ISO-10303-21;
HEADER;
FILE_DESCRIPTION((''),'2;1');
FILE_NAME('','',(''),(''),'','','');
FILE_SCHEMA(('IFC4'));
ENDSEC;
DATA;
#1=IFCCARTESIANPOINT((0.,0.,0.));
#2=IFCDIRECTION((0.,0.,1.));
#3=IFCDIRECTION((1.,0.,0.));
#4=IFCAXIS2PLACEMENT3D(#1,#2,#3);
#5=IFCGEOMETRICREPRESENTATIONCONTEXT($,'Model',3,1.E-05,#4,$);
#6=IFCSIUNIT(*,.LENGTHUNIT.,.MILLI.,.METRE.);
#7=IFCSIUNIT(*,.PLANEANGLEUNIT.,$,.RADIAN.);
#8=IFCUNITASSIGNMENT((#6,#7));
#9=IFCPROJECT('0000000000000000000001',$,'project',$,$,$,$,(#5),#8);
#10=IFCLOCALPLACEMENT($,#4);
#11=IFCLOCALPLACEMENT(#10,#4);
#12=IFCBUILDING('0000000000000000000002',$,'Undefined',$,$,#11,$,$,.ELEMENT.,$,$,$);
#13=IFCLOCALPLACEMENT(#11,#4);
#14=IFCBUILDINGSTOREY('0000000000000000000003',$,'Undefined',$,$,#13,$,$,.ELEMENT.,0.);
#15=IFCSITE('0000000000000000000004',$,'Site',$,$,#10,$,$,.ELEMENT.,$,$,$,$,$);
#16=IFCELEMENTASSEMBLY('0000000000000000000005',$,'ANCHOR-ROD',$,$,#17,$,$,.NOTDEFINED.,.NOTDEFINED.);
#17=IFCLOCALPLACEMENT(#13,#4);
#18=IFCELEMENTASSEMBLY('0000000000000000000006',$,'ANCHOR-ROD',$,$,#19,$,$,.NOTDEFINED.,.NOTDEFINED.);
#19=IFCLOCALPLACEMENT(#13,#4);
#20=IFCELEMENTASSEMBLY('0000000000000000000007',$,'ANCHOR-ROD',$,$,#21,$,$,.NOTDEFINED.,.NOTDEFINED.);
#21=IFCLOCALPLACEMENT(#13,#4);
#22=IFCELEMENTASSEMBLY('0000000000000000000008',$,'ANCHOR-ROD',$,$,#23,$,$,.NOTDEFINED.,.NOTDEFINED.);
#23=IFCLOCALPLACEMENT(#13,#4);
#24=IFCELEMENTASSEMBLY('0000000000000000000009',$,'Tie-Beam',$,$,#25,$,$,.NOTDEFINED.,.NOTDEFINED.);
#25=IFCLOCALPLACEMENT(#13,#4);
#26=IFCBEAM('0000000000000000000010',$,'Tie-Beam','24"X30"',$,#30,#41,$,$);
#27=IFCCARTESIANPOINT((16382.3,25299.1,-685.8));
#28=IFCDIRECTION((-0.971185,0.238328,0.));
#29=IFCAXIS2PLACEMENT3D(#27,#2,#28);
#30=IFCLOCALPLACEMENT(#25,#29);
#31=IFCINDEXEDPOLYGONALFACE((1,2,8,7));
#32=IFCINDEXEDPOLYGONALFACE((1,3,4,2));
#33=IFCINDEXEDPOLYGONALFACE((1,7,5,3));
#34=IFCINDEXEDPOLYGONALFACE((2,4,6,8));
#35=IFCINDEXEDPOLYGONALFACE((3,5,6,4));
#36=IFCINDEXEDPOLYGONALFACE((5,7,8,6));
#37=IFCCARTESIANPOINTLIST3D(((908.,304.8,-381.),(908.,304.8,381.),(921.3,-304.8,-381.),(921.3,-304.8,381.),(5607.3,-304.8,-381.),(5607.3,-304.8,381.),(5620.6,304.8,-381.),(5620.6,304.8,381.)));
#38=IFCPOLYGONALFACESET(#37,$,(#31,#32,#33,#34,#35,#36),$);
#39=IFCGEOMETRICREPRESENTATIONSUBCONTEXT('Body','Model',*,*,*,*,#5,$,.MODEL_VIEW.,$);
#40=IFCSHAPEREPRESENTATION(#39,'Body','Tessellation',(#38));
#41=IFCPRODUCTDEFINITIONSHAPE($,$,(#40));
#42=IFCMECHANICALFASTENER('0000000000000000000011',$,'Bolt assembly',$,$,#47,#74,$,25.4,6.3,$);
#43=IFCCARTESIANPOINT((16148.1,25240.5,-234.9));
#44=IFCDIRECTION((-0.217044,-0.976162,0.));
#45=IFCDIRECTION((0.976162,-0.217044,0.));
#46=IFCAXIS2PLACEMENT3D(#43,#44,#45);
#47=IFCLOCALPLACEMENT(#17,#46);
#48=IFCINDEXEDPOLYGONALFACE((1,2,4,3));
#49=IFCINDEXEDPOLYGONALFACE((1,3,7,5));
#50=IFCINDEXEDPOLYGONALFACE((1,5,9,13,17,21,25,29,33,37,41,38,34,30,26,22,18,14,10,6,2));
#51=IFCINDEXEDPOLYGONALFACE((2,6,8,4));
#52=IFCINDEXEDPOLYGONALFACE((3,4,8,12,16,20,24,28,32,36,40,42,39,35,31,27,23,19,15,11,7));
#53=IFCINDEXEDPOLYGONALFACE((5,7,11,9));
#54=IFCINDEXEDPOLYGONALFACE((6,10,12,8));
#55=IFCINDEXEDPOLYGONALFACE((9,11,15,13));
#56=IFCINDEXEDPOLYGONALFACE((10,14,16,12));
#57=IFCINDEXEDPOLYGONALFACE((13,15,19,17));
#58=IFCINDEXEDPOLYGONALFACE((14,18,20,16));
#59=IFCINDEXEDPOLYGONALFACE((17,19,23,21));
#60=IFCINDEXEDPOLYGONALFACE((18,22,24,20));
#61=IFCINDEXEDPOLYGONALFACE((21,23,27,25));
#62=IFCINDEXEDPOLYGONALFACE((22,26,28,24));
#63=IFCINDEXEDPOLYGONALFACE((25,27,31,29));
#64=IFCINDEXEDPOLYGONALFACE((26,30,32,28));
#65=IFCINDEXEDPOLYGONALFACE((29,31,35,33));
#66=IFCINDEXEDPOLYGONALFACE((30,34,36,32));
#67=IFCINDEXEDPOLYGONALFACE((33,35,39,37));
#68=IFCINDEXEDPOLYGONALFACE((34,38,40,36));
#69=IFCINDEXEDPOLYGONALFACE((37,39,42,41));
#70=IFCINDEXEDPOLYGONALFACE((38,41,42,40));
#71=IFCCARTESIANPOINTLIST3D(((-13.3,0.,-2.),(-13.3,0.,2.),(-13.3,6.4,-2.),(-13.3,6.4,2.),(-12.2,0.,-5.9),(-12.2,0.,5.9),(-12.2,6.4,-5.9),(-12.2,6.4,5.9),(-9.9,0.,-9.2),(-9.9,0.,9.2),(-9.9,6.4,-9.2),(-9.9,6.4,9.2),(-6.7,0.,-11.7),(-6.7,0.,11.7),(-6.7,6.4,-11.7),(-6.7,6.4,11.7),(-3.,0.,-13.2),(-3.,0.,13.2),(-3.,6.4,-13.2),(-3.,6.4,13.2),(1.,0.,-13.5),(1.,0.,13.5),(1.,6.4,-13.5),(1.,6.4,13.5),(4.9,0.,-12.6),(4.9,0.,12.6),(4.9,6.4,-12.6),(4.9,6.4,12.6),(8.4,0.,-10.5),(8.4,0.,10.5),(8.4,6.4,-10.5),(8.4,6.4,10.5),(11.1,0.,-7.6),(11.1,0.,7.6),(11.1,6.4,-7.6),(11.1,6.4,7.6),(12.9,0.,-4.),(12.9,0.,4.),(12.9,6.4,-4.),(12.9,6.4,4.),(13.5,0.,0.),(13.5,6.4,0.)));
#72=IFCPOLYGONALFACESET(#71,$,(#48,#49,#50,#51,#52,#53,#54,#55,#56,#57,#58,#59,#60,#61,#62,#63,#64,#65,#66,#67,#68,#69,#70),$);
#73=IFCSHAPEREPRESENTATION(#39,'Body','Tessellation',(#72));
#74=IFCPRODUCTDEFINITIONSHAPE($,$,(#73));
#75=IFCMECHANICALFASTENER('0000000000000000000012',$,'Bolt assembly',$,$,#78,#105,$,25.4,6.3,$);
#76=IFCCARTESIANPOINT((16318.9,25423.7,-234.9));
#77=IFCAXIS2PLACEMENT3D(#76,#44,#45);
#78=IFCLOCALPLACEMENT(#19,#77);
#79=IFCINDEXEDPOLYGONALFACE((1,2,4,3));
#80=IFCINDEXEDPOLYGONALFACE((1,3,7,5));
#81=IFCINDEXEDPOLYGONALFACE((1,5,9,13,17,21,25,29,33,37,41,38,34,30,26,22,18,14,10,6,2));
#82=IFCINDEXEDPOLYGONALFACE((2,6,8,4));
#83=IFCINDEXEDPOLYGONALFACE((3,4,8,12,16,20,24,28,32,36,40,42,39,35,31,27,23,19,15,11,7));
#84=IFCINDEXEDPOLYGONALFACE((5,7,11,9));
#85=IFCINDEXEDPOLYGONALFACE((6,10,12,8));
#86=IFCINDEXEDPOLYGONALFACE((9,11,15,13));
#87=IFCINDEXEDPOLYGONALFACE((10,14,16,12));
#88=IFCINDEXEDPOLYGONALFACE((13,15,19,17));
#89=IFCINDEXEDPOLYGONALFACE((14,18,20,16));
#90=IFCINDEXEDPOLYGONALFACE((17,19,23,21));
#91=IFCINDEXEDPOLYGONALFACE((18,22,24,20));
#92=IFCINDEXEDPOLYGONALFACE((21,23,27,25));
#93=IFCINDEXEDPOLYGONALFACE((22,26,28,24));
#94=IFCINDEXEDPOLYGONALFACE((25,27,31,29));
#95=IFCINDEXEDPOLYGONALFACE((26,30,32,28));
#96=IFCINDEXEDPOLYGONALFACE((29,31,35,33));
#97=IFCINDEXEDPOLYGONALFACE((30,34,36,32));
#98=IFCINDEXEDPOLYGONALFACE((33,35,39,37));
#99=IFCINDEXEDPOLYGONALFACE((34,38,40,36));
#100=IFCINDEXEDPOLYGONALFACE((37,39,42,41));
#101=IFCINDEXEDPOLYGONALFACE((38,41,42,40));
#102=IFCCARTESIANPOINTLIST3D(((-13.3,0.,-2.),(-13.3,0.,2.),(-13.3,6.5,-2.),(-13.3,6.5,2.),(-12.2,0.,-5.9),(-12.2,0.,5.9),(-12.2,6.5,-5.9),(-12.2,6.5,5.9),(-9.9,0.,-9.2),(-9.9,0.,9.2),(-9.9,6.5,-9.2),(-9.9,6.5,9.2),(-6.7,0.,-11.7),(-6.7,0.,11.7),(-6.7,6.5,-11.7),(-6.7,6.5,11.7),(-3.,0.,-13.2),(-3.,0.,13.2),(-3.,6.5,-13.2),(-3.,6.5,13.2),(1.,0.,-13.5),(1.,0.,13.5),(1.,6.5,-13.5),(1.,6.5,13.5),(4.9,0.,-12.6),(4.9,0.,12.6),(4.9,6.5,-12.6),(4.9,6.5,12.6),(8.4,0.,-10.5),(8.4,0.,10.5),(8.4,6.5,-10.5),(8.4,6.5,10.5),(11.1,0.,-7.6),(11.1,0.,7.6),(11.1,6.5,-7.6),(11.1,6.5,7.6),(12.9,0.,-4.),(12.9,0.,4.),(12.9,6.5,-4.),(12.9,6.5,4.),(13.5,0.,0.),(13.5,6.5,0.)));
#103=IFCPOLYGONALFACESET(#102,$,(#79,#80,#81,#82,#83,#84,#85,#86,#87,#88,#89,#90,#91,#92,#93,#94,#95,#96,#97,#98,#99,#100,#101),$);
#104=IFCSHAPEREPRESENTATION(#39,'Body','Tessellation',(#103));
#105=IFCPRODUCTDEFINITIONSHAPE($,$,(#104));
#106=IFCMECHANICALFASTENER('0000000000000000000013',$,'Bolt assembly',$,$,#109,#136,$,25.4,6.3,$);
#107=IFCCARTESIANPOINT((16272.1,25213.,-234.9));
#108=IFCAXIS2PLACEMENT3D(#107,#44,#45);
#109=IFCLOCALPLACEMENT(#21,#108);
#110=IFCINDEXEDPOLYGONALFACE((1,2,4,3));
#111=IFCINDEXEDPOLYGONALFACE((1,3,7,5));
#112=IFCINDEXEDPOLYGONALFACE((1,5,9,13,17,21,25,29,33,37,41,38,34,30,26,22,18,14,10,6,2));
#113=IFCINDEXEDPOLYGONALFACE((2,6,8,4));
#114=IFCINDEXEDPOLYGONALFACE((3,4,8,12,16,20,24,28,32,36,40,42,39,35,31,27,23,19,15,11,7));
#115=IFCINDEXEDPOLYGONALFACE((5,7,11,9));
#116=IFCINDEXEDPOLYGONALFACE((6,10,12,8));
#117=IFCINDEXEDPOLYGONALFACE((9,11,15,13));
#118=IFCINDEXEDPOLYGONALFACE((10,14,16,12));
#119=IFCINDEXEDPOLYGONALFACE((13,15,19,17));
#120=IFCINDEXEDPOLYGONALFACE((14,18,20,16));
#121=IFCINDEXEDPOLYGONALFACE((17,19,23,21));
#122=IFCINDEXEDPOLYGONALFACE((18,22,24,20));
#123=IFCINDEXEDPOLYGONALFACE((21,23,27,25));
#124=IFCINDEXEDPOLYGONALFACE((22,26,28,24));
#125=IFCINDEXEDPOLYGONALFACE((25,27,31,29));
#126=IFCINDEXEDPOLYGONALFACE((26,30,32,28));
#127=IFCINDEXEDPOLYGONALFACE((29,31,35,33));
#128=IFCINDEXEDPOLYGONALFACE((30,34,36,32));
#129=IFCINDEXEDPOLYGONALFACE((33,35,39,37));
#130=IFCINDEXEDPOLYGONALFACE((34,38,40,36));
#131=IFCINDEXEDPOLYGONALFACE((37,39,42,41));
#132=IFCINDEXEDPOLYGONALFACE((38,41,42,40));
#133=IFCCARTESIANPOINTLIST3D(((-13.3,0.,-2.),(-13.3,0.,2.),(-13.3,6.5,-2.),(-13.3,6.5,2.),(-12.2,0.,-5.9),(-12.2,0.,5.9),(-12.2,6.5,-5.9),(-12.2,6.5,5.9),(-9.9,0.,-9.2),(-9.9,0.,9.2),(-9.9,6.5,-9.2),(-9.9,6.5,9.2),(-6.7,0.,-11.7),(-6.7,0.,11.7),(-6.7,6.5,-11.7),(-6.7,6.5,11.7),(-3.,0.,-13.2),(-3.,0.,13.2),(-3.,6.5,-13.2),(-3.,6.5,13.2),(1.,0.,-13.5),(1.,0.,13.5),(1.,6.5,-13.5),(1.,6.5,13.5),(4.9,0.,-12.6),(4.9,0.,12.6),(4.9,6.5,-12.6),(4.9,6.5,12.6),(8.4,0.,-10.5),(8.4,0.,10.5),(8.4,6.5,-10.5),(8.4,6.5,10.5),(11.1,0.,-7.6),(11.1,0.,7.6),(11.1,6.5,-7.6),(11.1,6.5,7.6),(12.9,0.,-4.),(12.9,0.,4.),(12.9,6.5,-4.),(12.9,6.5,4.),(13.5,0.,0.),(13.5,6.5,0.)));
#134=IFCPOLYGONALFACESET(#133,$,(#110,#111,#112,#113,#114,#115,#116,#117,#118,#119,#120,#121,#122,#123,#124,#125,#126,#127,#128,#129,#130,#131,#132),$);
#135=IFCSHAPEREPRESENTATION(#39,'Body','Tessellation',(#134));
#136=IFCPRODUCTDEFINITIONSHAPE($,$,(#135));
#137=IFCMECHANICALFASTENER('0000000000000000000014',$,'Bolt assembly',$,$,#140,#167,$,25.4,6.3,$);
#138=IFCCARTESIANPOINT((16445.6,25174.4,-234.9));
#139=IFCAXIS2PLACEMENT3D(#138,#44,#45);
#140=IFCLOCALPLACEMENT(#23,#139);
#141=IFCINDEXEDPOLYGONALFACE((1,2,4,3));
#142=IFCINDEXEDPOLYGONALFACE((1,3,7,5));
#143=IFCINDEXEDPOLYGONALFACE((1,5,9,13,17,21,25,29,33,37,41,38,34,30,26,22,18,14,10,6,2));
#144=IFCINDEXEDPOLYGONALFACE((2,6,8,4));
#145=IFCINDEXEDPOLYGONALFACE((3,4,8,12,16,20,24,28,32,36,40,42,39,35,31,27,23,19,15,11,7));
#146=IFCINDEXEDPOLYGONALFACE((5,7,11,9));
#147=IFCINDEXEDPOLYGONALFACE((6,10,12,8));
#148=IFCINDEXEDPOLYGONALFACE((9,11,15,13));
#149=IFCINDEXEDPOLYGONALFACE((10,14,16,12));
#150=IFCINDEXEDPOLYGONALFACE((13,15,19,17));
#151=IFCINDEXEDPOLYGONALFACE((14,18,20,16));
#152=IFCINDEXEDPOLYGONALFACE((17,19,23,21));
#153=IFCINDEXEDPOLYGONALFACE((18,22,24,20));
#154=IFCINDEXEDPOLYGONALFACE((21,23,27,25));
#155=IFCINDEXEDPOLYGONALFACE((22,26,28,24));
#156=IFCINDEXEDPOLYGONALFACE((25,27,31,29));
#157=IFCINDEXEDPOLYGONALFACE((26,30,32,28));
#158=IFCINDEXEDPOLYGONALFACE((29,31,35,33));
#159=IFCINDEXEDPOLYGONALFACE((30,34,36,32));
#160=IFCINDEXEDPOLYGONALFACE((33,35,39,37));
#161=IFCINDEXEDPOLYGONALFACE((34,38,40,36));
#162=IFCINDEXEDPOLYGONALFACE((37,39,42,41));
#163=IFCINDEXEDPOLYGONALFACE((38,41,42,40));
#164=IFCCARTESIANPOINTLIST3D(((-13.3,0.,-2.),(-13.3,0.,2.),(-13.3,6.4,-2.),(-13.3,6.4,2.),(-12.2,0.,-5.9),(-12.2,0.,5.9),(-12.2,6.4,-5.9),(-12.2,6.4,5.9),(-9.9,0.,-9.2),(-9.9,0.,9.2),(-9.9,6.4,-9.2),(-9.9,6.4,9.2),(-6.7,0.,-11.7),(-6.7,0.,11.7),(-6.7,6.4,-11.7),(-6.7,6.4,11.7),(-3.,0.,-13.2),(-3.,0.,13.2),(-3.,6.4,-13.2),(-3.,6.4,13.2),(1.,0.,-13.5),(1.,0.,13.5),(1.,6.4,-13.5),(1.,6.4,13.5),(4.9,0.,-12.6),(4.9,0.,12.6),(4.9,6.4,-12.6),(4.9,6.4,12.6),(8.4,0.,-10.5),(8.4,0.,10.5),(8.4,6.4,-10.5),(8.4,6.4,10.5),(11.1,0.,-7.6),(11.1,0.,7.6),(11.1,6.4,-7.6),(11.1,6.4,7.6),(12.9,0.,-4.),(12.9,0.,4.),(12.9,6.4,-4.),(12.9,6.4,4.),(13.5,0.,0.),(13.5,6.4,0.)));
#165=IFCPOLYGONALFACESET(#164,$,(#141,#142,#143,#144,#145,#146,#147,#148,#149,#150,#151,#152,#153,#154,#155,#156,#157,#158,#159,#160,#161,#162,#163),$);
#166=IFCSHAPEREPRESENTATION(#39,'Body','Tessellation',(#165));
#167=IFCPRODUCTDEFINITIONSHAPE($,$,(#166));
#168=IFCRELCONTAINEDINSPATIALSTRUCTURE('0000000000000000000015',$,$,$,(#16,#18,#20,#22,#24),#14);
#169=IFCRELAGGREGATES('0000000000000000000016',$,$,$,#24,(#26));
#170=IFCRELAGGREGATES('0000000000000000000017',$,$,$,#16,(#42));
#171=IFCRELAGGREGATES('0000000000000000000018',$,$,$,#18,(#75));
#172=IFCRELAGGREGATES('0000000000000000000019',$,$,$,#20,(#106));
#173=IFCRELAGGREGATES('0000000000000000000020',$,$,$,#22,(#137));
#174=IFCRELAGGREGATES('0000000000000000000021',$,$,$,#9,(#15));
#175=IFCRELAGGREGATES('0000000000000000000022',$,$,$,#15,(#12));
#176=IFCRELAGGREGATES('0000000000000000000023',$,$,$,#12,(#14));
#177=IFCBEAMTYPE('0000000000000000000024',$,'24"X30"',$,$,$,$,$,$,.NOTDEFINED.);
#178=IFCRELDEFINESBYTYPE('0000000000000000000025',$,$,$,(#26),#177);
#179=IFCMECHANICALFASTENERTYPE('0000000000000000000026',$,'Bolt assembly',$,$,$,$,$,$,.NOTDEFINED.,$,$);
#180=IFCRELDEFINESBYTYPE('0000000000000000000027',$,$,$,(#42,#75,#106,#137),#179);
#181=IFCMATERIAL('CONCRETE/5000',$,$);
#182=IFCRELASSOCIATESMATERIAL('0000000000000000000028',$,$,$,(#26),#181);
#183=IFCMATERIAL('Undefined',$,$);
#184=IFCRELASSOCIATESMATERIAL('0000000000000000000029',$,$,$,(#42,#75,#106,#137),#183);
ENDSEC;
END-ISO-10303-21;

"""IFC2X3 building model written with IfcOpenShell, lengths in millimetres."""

from ifc_helpers import new_model, si_unit, frame, origin_with_axes, origin_2d_with_axis, place, context, subcontext, project, spatial, rectangle, circle, extrude, clip, halfspace, source, transform, mapped, material, type_object, element, aggregate, save


model = new_model("IFC2X3")

# Units and contexts
model_context = context("Model", 3, precision=1e-05, world=origin_with_axes())
body_context = subcontext(model_context, "Body", "Model", "MODEL_VIEW")
ifc_project = project(units=[si_unit("LENGTHUNIT", "METRE", prefix="MILLI"), si_unit("PLANEANGLEUNIT", "RADIAN")], contexts=[model_context])

# Site, building, storey
site_placement = place(None, origin_with_axes())
site = spatial("IfcSite", under=ifc_project, at=site_placement, Name="Site", CompositionType="ELEMENT")
building_placement = place(site_placement, origin_with_axes())
building = spatial("IfcBuilding", under=site, at=building_placement, Name="Undefined", CompositionType="ELEMENT")
storey_placement = place(building_placement, origin_with_axes())
storey = spatial("IfcBuildingStorey", under=building, at=storey_placement, Name="Undefined", CompositionType="ELEMENT", Elevation=0.0)

# Element assemblies
assembly_1_placement = place(storey_placement, origin_with_axes())
assembly_1 = element("IfcElementAssembly", 1, at=assembly_1_placement, inside=storey, Name="ANCHOR-ROD", AssemblyPlace="NOTDEFINED", PredefinedType="NOTDEFINED")
assembly_2_placement = place(storey_placement, origin_with_axes())
assembly_2 = element("IfcElementAssembly", 2, at=assembly_2_placement, inside=storey, Name="ANCHOR-ROD", AssemblyPlace="NOTDEFINED", PredefinedType="NOTDEFINED")
assembly_3_placement = place(storey_placement, origin_with_axes())
assembly_3 = element("IfcElementAssembly", 3, at=assembly_3_placement, inside=storey, Name="ANCHOR-ROD", AssemblyPlace="NOTDEFINED", PredefinedType="NOTDEFINED")
assembly_4_placement = place(storey_placement, origin_with_axes())
assembly_4 = element("IfcElementAssembly", 4, at=assembly_4_placement, inside=storey, Name="ANCHOR-ROD", AssemblyPlace="NOTDEFINED", PredefinedType="NOTDEFINED")

# Element assembly, beam
assembly_5_placement = place(storey_placement, origin_with_axes())
assembly_5 = element("IfcElementAssembly", 5, at=assembly_5_placement, inside=storey, Name="Tie-Beam", AssemblyPlace="NOTDEFINED", PredefinedType="NOTDEFINED")
ifc_material_1 = material(Name="CONCRETE/5000")
beam_type = type_object("IfcBeamType", Name="24\"X30\"", PredefinedType="NOTDEFINED")
beam_placement = place(assembly_5_placement, frame((16382.3, 25299.1, -685.8), z_axis=(0.0, 0.0, 1.0), x_axis=(-0.971185, 0.238328, 0.0)))
beam = element("IfcBeam", 6, at=beam_placement, type_object=beam_type, material=ifc_material_1, Name="Tie-Beam", Description="24\"X30\"", context=body_context, shape_type="Clipping", body=[
    clip(clip(extrude(rectangle(XDim=609.6, YDim=762.0, at=origin_2d_with_axis()), frame((6528.6, 0.0, 0.0), z_axis=(-1.0, 0.0, 0.0), x_axis=(0.0, -1.0, 0.0)), (0.0, 0.0, 1.0), 6528.6), halfspace(frame((5614.0, 0.0, -1000.0), z_axis=(-0.99976, 0.021893, 0.0), x_axis=(0.021893, 0.99976, 0.0)), True)), halfspace(frame((914.6, 0.0, -1000.0), z_axis=(0.999761, 0.021857, 0.0), x_axis=(0.021857, -0.999761, 0.0)), True)),
])
aggregate(assembly_5, [beam])

# Mechanical fasteners
ifc_material_2 = material(Name="Undefined")
mechanical_fastener_type = type_object("IfcMechanicalFastenerType", Name="Bolt assembly")
shared_shape = source(origin_with_axes(), body_context, "Body", "SweptSolid", [
    extrude(circle(Radius=13.5, at=origin_2d_with_axis()), frame((0.0, 0.0, 0.0), z_axis=(0.0, 1.0, 0.0), x_axis=(1.0, 0.0, 0.0)), (0.0, 0.0, 1.0), 6.5),
])
mechanical_fastener_1_placement = place(assembly_1_placement, frame((16148.1, 25240.5, -234.9), z_axis=(-0.217044, -0.976162, 0.0), x_axis=(0.976162, -0.217044, 0.0)))
mechanical_fastener_1 = element("IfcMechanicalFastener", 7, at=mechanical_fastener_1_placement, type_object=mechanical_fastener_type, material=ifc_material_2, Name="Bolt assembly", NominalDiameter=25.4, NominalLength=6.3, context=body_context, shape_type="MappedRepresentation", body=[
    mapped(shared_shape, transform((0.0, 0.0, 0.0))),
])
aggregate(assembly_1, [mechanical_fastener_1])
mechanical_fastener_2_placement = place(assembly_2_placement, frame((16318.9, 25423.7, -234.9), z_axis=(-0.217044, -0.976162, 0.0), x_axis=(0.976162, -0.217044, 0.0)))
mechanical_fastener_2 = element("IfcMechanicalFastener", 8, at=mechanical_fastener_2_placement, type_object=mechanical_fastener_type, material=ifc_material_2, Name="Bolt assembly", NominalDiameter=25.4, NominalLength=6.3, context=body_context, shape_type="MappedRepresentation", body=[
    mapped(shared_shape, transform((0.0, 0.0, 0.0))),
])
aggregate(assembly_2, [mechanical_fastener_2])
mechanical_fastener_3_placement = place(assembly_3_placement, frame((16272.1, 25213.0, -234.9), z_axis=(-0.217044, -0.976162, 0.0), x_axis=(0.976162, -0.217044, 0.0)))
mechanical_fastener_3 = element("IfcMechanicalFastener", 9, at=mechanical_fastener_3_placement, type_object=mechanical_fastener_type, material=ifc_material_2, Name="Bolt assembly", NominalDiameter=25.4, NominalLength=6.3, context=body_context, shape_type="MappedRepresentation", body=[
    mapped(shared_shape, transform((0.0, 0.0, 0.0))),
])
aggregate(assembly_3, [mechanical_fastener_3])
mechanical_fastener_4_placement = place(assembly_4_placement, frame((16445.6, 25174.4, -234.9), z_axis=(-0.217044, -0.976162, 0.0), x_axis=(0.976162, -0.217044, 0.0)))
mechanical_fastener_4 = element("IfcMechanicalFastener", 10, at=mechanical_fastener_4_placement, type_object=mechanical_fastener_type, material=ifc_material_2, Name="Bolt assembly", NominalDiameter=25.4, NominalLength=6.3, context=body_context, shape_type="MappedRepresentation", body=[
    mapped(shared_shape, transform((0.0, 0.0, 0.0))),
])
aggregate(assembly_4, [mechanical_fastener_4])

save(model, "model.ifc")
